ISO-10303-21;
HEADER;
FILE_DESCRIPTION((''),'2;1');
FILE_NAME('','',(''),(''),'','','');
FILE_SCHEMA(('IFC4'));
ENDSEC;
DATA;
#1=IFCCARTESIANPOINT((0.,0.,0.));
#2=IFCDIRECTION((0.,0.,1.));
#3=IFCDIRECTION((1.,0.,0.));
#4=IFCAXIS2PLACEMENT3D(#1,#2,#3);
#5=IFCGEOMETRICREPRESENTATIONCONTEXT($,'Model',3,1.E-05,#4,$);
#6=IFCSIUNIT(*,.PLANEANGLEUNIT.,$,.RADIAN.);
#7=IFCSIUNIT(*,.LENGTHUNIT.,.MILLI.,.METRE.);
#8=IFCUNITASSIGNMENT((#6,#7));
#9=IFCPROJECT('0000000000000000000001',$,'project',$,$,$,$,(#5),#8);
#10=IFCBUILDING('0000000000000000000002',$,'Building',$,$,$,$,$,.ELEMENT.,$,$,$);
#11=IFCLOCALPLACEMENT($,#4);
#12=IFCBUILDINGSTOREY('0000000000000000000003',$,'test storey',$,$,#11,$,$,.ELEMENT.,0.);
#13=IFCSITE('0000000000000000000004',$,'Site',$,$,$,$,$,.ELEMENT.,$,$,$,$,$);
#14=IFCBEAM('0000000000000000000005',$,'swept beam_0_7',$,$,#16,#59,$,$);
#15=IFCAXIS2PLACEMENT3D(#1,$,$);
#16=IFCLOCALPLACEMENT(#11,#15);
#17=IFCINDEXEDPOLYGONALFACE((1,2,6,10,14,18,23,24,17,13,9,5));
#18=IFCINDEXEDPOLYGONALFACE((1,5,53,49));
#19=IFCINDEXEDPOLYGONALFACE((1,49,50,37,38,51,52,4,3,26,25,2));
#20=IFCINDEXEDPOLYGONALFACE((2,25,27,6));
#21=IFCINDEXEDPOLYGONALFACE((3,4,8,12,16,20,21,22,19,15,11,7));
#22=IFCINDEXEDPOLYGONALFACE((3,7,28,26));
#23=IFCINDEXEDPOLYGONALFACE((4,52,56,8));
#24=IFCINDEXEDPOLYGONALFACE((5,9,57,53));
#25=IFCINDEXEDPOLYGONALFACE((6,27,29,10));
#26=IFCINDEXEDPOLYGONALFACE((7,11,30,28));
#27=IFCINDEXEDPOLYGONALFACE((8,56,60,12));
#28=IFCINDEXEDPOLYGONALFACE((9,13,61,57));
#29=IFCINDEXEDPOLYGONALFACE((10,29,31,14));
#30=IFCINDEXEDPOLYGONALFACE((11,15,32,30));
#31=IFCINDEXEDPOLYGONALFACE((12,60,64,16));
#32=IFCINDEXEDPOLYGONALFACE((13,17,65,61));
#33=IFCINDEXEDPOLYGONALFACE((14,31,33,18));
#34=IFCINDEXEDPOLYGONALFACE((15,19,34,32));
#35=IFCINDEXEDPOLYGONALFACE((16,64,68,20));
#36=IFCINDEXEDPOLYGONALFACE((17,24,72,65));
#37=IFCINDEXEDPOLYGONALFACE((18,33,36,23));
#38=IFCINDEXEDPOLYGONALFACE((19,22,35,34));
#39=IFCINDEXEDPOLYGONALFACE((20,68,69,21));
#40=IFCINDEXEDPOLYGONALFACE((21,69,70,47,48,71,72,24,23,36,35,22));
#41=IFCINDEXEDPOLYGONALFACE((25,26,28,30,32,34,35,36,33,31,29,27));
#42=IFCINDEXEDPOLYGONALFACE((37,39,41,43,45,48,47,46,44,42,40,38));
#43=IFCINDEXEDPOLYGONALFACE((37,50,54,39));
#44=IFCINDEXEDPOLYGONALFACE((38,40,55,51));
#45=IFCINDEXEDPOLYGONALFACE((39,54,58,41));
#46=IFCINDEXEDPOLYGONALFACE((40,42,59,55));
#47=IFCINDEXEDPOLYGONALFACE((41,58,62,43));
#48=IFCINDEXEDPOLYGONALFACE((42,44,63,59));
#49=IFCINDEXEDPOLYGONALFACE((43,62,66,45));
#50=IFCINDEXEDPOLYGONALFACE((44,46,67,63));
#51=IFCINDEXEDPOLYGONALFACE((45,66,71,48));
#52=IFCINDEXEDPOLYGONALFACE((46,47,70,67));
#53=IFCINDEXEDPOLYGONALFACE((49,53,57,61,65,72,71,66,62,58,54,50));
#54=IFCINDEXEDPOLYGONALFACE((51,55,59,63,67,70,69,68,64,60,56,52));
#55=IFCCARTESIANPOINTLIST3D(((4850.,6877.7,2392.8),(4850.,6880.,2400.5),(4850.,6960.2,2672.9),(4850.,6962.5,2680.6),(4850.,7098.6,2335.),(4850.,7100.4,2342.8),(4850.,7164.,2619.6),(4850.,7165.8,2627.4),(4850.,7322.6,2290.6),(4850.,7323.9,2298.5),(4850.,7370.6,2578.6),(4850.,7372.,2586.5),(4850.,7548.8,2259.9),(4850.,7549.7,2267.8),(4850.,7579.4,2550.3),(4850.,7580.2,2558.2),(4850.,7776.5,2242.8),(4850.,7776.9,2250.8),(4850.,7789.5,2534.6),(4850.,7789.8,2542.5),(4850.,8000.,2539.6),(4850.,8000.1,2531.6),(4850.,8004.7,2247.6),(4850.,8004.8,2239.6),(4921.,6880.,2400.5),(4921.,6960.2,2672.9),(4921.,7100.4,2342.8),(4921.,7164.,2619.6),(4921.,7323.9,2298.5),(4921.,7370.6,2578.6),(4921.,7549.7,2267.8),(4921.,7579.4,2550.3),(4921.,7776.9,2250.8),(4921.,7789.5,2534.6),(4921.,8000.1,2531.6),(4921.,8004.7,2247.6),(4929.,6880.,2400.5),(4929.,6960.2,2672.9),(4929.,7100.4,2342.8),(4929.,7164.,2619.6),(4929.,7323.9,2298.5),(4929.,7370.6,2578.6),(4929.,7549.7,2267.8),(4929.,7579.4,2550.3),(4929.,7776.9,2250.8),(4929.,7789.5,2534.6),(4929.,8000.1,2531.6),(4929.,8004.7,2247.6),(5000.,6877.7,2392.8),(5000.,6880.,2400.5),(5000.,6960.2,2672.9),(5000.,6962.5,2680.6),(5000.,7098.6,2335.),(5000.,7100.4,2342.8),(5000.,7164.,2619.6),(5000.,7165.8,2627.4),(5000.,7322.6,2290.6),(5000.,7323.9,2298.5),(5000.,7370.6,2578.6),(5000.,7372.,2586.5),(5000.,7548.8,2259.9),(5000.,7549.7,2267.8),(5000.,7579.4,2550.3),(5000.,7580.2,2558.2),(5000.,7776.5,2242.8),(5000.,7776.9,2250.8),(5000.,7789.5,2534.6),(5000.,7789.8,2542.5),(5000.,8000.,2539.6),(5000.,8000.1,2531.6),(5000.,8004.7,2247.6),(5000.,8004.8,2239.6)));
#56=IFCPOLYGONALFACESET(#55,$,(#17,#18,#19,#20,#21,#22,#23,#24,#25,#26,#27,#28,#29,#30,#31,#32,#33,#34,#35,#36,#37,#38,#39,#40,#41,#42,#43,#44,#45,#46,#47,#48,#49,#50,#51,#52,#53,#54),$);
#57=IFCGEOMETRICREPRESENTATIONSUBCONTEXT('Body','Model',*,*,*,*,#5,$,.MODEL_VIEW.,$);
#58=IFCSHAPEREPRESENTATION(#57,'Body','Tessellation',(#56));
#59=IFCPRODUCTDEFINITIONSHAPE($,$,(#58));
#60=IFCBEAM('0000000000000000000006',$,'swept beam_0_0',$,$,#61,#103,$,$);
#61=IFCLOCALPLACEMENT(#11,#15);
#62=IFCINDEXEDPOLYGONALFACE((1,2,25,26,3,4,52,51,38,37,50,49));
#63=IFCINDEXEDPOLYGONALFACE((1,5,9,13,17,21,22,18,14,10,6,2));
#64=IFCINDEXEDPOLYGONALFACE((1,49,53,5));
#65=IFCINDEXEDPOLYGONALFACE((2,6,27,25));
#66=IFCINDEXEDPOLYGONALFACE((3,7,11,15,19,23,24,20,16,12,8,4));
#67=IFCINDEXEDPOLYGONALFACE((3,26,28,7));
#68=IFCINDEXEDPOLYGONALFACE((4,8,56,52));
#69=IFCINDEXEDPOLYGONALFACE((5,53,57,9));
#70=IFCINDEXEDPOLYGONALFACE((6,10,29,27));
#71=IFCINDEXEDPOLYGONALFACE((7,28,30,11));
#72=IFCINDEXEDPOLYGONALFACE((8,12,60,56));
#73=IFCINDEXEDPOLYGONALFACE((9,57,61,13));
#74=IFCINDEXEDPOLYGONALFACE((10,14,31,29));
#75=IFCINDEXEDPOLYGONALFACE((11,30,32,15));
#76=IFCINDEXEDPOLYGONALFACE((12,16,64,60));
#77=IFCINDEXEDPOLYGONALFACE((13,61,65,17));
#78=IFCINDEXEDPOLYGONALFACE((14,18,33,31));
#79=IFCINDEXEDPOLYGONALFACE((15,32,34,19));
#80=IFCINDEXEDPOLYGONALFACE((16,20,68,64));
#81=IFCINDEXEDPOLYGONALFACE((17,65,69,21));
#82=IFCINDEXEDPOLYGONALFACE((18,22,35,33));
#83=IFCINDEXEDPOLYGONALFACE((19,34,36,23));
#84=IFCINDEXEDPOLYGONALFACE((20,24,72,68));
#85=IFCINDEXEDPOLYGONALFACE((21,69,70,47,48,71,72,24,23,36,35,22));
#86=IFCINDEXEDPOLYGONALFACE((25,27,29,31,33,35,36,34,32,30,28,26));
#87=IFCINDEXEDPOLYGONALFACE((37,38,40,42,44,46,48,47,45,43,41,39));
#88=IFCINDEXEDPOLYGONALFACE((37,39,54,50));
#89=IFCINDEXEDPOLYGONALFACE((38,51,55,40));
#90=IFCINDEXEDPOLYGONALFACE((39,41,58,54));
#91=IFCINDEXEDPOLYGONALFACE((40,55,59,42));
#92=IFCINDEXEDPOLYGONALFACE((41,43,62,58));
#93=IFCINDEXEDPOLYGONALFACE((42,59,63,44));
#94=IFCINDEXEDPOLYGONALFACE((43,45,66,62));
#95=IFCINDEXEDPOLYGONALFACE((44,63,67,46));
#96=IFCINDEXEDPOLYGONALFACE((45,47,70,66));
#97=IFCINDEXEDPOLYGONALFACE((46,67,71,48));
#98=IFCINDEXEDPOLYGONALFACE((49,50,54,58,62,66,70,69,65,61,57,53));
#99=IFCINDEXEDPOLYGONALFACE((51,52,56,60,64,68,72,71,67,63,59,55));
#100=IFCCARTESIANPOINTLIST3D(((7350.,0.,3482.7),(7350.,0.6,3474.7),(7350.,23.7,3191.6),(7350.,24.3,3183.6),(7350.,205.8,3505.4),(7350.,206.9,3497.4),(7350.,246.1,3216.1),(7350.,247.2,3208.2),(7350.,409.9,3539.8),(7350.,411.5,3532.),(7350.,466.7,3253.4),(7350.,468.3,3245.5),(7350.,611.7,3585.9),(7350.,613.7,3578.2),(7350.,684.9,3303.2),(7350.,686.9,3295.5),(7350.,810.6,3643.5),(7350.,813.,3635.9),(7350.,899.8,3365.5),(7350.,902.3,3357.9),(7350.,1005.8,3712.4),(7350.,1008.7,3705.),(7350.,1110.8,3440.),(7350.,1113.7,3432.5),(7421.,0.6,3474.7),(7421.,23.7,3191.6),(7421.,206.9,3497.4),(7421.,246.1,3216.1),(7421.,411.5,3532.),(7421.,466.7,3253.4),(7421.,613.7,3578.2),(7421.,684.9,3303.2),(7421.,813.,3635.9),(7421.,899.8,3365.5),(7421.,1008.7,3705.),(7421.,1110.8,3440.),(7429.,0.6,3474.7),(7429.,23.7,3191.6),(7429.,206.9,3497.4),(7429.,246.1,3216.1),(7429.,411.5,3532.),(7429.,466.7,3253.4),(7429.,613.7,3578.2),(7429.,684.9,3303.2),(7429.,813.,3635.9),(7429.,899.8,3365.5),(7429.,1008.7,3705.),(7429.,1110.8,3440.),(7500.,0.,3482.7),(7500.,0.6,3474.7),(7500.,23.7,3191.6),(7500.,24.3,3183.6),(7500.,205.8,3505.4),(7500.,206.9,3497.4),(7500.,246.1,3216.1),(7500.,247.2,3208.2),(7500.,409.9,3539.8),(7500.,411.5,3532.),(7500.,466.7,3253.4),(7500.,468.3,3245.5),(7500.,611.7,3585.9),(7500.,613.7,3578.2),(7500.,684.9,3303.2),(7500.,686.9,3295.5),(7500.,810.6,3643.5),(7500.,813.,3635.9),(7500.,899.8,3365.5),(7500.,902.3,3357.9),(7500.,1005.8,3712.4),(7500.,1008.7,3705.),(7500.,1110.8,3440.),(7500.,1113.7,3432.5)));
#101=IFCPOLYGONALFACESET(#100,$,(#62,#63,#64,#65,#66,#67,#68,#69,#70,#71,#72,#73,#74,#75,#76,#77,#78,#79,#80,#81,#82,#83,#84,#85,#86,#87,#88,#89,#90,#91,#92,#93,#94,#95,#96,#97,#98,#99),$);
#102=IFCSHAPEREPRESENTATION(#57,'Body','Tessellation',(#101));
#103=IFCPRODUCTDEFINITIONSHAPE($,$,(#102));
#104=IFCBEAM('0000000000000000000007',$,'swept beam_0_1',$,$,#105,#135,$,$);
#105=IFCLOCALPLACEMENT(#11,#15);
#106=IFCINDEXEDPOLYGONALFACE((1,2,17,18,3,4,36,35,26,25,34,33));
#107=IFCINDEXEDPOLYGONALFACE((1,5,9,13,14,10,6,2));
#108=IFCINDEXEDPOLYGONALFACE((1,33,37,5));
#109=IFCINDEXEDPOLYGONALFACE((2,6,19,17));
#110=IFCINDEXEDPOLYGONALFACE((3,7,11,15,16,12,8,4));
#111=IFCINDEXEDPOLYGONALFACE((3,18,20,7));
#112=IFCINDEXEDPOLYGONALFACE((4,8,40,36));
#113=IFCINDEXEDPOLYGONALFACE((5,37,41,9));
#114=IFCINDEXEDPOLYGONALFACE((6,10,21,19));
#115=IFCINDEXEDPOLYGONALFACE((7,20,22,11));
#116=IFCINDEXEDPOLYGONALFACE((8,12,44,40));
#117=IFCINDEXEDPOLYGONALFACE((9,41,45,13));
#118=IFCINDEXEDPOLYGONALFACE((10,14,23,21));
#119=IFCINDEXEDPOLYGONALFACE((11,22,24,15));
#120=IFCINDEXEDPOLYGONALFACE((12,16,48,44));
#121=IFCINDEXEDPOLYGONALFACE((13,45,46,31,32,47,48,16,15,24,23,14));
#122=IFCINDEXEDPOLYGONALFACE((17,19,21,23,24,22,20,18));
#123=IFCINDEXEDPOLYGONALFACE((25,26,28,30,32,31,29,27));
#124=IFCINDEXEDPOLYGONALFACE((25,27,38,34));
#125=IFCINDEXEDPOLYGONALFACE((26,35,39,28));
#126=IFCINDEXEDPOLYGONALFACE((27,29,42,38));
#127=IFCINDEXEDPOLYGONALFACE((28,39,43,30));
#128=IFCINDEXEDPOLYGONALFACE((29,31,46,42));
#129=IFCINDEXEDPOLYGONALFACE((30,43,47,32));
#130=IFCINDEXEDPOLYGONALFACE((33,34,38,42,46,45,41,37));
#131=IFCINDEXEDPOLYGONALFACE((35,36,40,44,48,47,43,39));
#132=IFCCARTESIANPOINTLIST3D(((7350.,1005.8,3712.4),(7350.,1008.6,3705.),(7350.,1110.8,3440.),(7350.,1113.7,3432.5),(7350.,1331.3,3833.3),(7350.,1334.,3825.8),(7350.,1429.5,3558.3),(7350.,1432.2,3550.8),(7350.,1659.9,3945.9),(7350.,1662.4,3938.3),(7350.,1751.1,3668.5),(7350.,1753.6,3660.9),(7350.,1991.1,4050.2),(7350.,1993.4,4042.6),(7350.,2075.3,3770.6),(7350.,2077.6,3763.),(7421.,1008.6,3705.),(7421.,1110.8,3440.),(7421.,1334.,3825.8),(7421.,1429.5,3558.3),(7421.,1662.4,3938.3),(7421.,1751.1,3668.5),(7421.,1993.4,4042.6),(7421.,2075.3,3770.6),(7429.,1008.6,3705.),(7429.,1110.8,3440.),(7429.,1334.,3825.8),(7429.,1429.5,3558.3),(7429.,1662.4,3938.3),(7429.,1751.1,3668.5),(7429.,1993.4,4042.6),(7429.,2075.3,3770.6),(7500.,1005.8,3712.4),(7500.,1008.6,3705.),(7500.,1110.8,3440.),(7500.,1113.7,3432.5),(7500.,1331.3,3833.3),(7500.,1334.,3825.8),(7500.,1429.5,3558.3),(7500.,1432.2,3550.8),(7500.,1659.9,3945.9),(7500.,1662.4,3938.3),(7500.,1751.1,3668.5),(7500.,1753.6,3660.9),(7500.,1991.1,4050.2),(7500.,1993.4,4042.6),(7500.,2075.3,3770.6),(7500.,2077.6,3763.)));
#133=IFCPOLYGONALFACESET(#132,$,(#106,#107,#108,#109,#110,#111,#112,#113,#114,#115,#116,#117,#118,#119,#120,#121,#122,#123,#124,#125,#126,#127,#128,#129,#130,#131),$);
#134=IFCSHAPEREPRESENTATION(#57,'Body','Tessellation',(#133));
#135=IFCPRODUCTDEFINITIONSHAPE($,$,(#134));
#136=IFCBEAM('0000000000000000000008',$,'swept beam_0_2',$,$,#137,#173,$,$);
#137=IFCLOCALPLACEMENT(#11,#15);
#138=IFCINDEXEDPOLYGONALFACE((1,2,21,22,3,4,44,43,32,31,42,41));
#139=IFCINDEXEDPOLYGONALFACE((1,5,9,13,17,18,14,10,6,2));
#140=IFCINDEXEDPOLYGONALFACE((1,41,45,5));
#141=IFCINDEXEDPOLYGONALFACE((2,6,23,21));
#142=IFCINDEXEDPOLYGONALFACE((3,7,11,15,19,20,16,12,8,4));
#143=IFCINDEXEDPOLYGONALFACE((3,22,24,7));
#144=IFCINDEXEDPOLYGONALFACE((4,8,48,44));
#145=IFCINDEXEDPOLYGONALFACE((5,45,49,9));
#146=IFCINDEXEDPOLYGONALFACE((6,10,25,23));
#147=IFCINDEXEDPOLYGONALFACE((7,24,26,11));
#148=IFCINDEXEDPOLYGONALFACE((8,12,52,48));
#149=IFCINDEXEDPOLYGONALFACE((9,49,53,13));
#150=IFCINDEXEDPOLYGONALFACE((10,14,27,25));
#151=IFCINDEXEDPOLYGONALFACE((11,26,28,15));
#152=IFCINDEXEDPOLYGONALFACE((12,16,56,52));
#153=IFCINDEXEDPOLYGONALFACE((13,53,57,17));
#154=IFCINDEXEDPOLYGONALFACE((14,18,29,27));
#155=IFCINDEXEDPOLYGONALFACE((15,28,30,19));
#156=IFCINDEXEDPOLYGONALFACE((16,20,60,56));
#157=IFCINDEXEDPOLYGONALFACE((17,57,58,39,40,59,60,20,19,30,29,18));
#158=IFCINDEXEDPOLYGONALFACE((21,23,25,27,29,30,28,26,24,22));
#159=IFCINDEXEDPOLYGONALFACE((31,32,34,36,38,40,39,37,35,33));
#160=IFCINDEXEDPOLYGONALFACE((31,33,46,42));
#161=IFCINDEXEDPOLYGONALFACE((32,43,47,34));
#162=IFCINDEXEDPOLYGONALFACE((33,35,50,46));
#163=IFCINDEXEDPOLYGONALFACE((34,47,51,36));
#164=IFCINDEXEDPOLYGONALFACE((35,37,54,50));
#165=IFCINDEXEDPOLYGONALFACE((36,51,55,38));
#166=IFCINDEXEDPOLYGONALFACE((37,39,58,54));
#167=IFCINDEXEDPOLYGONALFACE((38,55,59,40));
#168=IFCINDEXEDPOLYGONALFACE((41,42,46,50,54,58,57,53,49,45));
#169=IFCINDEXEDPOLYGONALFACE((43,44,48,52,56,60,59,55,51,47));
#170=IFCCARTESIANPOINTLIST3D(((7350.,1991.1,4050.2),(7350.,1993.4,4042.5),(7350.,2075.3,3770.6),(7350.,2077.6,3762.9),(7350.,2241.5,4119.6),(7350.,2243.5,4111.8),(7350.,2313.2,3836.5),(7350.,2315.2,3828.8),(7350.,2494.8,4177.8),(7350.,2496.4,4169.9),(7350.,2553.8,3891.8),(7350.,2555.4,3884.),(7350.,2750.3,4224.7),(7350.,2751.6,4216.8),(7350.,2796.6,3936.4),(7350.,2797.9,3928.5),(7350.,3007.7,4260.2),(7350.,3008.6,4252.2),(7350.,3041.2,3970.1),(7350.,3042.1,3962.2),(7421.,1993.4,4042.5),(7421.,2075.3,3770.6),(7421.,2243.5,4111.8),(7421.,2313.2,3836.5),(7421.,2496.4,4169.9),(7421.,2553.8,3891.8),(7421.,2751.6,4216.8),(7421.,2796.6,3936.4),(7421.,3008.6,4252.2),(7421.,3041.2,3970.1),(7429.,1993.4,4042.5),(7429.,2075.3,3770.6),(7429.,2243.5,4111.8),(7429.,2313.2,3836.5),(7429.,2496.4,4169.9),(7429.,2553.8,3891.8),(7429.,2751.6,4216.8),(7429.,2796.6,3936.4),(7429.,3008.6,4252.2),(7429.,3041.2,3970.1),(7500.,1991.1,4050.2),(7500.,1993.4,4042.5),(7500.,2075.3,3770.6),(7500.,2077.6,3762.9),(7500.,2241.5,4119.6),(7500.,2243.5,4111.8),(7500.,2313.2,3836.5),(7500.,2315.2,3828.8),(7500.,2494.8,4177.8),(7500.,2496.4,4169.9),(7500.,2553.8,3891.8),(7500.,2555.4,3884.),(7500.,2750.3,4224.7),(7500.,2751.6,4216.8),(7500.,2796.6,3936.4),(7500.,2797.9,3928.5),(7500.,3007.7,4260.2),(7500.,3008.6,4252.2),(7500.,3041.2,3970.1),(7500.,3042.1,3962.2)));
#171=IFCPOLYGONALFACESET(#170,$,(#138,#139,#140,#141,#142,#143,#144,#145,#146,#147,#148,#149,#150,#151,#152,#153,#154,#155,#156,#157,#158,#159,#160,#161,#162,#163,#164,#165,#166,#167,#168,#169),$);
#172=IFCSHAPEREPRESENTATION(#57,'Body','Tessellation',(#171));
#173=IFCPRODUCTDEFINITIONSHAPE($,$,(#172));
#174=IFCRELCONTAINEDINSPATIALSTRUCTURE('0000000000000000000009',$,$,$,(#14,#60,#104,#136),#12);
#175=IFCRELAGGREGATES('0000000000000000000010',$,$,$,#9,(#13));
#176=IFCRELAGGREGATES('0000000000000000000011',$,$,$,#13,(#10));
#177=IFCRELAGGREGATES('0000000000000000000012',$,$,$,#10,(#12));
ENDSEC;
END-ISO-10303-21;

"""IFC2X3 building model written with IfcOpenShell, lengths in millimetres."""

from ifc_helpers import new_model, entity, si_unit, origin_with_axes, place, context, subcontext, project, spatial, element, save


model = new_model("IFC2X3")

# Units and contexts
model_context = context("Model", 3, precision=1e-05, world=origin_with_axes())
body_context = subcontext(model_context, "Body", "Model", "MODEL_VIEW")
ifc_project = project(units=[si_unit("PLANEANGLEUNIT", "RADIAN"), si_unit("LENGTHUNIT", "METRE", prefix="MILLI")], contexts=[model_context])

# Site, building, storey
site = spatial("IfcSite", under=ifc_project, Name="Site", CompositionType="ELEMENT")
building = spatial("IfcBuilding", under=site, Name="Building", CompositionType="ELEMENT")
storey_placement = place(None, origin_with_axes())
storey = spatial("IfcBuildingStorey", under=building, at=storey_placement, Name="test storey", CompositionType="ELEMENT", Elevation=0.0)

# Beams
beam_1_placement = place(storey_placement, origin_with_axes())
element("IfcBeam", 1, at=beam_1_placement, inside=storey, Name="swept beam_0_7", context=body_context, shape_type="SweptSolid", body=[
    entity("IfcRevolvedAreaSolid", entity("IfcArbitraryClosedProfileDef", "AREA", None, entity("IfcPolyline", [entity("IfcCartesianPoint", [292.0, 0.0]), entity("IfcCartesianPoint", [292.0, -71.0]), entity("IfcCartesianPoint", [8.0, -71.0]), entity("IfcCartesianPoint", [8.0, 0.0]), entity("IfcCartesianPoint", [0.0, 0.0]), entity("IfcCartesianPoint", [0.0, -150.0]), entity("IfcCartesianPoint", [8.0, -150.0]), entity("IfcCartesianPoint", [8.0, -79.0]), entity("IfcCartesianPoint", [292.0, -79.0]), entity("IfcCartesianPoint", [292.0, -150.0]), entity("IfcCartesianPoint", [300.0, -150.0]), entity("IfcCartesianPoint", [300.0, 0.0]), entity("IfcCartesianPoint", [292.0, 0.0])])), entity("IfcAxis2Placement3D", entity("IfcCartesianPoint", [5000.0, 6962.5, 2680.6]), entity("IfcDirection", [0.0, -0.9593, 0.2824]), entity("IfcDirection", [0.0, -0.2824, -0.9593])), entity("IfcAxis1Placement", entity("IfcCartesianPoint", [-3475.9, 0.0, 0.0]), entity("IfcDirection", [0.0, 1.0, 0.0])), 0.302398),
])
beam_2_placement = place(storey_placement, origin_with_axes())
element("IfcBeam", 2, at=beam_2_placement, inside=storey, Name="swept beam_0_0", context=body_context, shape_type="SweptSolid", body=[
    entity("IfcRevolvedAreaSolid", entity("IfcArbitraryClosedProfileDef", "AREA", None, entity("IfcPolyline", [entity("IfcCartesianPoint", [292.0, 0.0]), entity("IfcCartesianPoint", [292.0, -71.0]), entity("IfcCartesianPoint", [8.0, -71.0]), entity("IfcCartesianPoint", [8.0, 0.0]), entity("IfcCartesianPoint", [0.0, 0.0]), entity("IfcCartesianPoint", [0.0, -150.0]), entity("IfcCartesianPoint", [8.0, -150.0]), entity("IfcCartesianPoint", [8.0, -79.0]), entity("IfcCartesianPoint", [292.0, -79.0]), entity("IfcCartesianPoint", [292.0, -150.0]), entity("IfcCartesianPoint", [300.0, -150.0]), entity("IfcCartesianPoint", [300.0, 0.0]), entity("IfcCartesianPoint", [292.0, 0.0])])), entity("IfcAxis2Placement3D", entity("IfcCartesianPoint", [7500.0, 0.0, 3482.7]), entity("IfcDirection", [0.0, -0.9967, -0.0811]), entity("IfcDirection", [0.0, 0.0811, -0.9967])), entity("IfcAxis1Placement", entity("IfcCartesianPoint", [-3609.4, 0.0, 0.0]), entity("IfcDirection", [0.0, 1.0, 0.0])), 0.286818),
])
beam_3_placement = place(storey_placement, origin_with_axes())
element("IfcBeam", 3, at=beam_3_placement, inside=storey, Name="swept beam_0_1", context=body_context, shape_type="SweptSolid", body=[
    entity("IfcRevolvedAreaSolid", entity("IfcArbitraryClosedProfileDef", "AREA", None, entity("IfcPolyline", [entity("IfcCartesianPoint", [-292.0, 0.0]), entity("IfcCartesianPoint", [-292.0, 71.0]), entity("IfcCartesianPoint", [-8.0, 71.0]), entity("IfcCartesianPoint", [-8.0, 0.0]), entity("IfcCartesianPoint", [0.0, 0.0]), entity("IfcCartesianPoint", [0.0, 150.0]), entity("IfcCartesianPoint", [-8.0, 150.0]), entity("IfcCartesianPoint", [-8.0, 79.0]), entity("IfcCartesianPoint", [-292.0, 79.0]), entity("IfcCartesianPoint", [-292.0, 150.0]), entity("IfcCartesianPoint", [-300.0, 150.0]), entity("IfcCartesianPoint", [-300.0, 0.0]), entity("IfcCartesianPoint", [-292.0, 0.0])])), entity("IfcAxis2Placement3D", entity("IfcCartesianPoint", [7500.0, 1005.8, 3712.4]), entity("IfcDirection", [0.0, -0.933, -0.3598]), entity("IfcDirection", [0.0, -0.3598, 0.933])), entity("IfcAxis1Placement", entity("IfcCartesianPoint", [-13782.3, 0.0, 0.0]), entity("IfcDirection", [0.0, 1.0, 0.0])), 0.075596),
])
beam_4_placement = place(storey_placement, origin_with_axes())
element("IfcBeam", 4, at=beam_4_placement, inside=storey, Name="swept beam_0_2", context=body_context, shape_type="SweptSolid", body=[
    entity("IfcRevolvedAreaSolid", entity("IfcArbitraryClosedProfileDef", "AREA", None, entity("IfcPolyline", [entity("IfcCartesianPoint", [-292.0, 0.0]), entity("IfcCartesianPoint", [-292.0, 71.0]), entity("IfcCartesianPoint", [-8.0, 71.0]), entity("IfcCartesianPoint", [-8.0, 0.0]), entity("IfcCartesianPoint", [0.0, 0.0]), entity("IfcCartesianPoint", [0.0, 150.0]), entity("IfcCartesianPoint", [-8.0, 150.0]), entity("IfcCartesianPoint", [-8.0, 79.0]), entity("IfcCartesianPoint", [-292.0, 79.0]), entity("IfcCartesianPoint", [-292.0, 150.0]), entity("IfcCartesianPoint", [-300.0, 150.0]), entity("IfcCartesianPoint", [-300.0, 0.0]), entity("IfcCartesianPoint", [-292.0, 0.0])])), entity("IfcAxis2Placement3D", entity("IfcCartesianPoint", [7500.0, 1991.1, 4050.2]), entity("IfcDirection", [0.0, -0.9575, -0.2883]), entity("IfcDirection", [0.0, -0.2883, 0.9575])), entity("IfcAxis1Placement", entity("IfcCartesianPoint", [-5854.2, 0.0, 0.0]), entity("IfcDirection", [0.0, 1.0, 0.0])), 0.177545),
])

save(model, "model.ifc")
